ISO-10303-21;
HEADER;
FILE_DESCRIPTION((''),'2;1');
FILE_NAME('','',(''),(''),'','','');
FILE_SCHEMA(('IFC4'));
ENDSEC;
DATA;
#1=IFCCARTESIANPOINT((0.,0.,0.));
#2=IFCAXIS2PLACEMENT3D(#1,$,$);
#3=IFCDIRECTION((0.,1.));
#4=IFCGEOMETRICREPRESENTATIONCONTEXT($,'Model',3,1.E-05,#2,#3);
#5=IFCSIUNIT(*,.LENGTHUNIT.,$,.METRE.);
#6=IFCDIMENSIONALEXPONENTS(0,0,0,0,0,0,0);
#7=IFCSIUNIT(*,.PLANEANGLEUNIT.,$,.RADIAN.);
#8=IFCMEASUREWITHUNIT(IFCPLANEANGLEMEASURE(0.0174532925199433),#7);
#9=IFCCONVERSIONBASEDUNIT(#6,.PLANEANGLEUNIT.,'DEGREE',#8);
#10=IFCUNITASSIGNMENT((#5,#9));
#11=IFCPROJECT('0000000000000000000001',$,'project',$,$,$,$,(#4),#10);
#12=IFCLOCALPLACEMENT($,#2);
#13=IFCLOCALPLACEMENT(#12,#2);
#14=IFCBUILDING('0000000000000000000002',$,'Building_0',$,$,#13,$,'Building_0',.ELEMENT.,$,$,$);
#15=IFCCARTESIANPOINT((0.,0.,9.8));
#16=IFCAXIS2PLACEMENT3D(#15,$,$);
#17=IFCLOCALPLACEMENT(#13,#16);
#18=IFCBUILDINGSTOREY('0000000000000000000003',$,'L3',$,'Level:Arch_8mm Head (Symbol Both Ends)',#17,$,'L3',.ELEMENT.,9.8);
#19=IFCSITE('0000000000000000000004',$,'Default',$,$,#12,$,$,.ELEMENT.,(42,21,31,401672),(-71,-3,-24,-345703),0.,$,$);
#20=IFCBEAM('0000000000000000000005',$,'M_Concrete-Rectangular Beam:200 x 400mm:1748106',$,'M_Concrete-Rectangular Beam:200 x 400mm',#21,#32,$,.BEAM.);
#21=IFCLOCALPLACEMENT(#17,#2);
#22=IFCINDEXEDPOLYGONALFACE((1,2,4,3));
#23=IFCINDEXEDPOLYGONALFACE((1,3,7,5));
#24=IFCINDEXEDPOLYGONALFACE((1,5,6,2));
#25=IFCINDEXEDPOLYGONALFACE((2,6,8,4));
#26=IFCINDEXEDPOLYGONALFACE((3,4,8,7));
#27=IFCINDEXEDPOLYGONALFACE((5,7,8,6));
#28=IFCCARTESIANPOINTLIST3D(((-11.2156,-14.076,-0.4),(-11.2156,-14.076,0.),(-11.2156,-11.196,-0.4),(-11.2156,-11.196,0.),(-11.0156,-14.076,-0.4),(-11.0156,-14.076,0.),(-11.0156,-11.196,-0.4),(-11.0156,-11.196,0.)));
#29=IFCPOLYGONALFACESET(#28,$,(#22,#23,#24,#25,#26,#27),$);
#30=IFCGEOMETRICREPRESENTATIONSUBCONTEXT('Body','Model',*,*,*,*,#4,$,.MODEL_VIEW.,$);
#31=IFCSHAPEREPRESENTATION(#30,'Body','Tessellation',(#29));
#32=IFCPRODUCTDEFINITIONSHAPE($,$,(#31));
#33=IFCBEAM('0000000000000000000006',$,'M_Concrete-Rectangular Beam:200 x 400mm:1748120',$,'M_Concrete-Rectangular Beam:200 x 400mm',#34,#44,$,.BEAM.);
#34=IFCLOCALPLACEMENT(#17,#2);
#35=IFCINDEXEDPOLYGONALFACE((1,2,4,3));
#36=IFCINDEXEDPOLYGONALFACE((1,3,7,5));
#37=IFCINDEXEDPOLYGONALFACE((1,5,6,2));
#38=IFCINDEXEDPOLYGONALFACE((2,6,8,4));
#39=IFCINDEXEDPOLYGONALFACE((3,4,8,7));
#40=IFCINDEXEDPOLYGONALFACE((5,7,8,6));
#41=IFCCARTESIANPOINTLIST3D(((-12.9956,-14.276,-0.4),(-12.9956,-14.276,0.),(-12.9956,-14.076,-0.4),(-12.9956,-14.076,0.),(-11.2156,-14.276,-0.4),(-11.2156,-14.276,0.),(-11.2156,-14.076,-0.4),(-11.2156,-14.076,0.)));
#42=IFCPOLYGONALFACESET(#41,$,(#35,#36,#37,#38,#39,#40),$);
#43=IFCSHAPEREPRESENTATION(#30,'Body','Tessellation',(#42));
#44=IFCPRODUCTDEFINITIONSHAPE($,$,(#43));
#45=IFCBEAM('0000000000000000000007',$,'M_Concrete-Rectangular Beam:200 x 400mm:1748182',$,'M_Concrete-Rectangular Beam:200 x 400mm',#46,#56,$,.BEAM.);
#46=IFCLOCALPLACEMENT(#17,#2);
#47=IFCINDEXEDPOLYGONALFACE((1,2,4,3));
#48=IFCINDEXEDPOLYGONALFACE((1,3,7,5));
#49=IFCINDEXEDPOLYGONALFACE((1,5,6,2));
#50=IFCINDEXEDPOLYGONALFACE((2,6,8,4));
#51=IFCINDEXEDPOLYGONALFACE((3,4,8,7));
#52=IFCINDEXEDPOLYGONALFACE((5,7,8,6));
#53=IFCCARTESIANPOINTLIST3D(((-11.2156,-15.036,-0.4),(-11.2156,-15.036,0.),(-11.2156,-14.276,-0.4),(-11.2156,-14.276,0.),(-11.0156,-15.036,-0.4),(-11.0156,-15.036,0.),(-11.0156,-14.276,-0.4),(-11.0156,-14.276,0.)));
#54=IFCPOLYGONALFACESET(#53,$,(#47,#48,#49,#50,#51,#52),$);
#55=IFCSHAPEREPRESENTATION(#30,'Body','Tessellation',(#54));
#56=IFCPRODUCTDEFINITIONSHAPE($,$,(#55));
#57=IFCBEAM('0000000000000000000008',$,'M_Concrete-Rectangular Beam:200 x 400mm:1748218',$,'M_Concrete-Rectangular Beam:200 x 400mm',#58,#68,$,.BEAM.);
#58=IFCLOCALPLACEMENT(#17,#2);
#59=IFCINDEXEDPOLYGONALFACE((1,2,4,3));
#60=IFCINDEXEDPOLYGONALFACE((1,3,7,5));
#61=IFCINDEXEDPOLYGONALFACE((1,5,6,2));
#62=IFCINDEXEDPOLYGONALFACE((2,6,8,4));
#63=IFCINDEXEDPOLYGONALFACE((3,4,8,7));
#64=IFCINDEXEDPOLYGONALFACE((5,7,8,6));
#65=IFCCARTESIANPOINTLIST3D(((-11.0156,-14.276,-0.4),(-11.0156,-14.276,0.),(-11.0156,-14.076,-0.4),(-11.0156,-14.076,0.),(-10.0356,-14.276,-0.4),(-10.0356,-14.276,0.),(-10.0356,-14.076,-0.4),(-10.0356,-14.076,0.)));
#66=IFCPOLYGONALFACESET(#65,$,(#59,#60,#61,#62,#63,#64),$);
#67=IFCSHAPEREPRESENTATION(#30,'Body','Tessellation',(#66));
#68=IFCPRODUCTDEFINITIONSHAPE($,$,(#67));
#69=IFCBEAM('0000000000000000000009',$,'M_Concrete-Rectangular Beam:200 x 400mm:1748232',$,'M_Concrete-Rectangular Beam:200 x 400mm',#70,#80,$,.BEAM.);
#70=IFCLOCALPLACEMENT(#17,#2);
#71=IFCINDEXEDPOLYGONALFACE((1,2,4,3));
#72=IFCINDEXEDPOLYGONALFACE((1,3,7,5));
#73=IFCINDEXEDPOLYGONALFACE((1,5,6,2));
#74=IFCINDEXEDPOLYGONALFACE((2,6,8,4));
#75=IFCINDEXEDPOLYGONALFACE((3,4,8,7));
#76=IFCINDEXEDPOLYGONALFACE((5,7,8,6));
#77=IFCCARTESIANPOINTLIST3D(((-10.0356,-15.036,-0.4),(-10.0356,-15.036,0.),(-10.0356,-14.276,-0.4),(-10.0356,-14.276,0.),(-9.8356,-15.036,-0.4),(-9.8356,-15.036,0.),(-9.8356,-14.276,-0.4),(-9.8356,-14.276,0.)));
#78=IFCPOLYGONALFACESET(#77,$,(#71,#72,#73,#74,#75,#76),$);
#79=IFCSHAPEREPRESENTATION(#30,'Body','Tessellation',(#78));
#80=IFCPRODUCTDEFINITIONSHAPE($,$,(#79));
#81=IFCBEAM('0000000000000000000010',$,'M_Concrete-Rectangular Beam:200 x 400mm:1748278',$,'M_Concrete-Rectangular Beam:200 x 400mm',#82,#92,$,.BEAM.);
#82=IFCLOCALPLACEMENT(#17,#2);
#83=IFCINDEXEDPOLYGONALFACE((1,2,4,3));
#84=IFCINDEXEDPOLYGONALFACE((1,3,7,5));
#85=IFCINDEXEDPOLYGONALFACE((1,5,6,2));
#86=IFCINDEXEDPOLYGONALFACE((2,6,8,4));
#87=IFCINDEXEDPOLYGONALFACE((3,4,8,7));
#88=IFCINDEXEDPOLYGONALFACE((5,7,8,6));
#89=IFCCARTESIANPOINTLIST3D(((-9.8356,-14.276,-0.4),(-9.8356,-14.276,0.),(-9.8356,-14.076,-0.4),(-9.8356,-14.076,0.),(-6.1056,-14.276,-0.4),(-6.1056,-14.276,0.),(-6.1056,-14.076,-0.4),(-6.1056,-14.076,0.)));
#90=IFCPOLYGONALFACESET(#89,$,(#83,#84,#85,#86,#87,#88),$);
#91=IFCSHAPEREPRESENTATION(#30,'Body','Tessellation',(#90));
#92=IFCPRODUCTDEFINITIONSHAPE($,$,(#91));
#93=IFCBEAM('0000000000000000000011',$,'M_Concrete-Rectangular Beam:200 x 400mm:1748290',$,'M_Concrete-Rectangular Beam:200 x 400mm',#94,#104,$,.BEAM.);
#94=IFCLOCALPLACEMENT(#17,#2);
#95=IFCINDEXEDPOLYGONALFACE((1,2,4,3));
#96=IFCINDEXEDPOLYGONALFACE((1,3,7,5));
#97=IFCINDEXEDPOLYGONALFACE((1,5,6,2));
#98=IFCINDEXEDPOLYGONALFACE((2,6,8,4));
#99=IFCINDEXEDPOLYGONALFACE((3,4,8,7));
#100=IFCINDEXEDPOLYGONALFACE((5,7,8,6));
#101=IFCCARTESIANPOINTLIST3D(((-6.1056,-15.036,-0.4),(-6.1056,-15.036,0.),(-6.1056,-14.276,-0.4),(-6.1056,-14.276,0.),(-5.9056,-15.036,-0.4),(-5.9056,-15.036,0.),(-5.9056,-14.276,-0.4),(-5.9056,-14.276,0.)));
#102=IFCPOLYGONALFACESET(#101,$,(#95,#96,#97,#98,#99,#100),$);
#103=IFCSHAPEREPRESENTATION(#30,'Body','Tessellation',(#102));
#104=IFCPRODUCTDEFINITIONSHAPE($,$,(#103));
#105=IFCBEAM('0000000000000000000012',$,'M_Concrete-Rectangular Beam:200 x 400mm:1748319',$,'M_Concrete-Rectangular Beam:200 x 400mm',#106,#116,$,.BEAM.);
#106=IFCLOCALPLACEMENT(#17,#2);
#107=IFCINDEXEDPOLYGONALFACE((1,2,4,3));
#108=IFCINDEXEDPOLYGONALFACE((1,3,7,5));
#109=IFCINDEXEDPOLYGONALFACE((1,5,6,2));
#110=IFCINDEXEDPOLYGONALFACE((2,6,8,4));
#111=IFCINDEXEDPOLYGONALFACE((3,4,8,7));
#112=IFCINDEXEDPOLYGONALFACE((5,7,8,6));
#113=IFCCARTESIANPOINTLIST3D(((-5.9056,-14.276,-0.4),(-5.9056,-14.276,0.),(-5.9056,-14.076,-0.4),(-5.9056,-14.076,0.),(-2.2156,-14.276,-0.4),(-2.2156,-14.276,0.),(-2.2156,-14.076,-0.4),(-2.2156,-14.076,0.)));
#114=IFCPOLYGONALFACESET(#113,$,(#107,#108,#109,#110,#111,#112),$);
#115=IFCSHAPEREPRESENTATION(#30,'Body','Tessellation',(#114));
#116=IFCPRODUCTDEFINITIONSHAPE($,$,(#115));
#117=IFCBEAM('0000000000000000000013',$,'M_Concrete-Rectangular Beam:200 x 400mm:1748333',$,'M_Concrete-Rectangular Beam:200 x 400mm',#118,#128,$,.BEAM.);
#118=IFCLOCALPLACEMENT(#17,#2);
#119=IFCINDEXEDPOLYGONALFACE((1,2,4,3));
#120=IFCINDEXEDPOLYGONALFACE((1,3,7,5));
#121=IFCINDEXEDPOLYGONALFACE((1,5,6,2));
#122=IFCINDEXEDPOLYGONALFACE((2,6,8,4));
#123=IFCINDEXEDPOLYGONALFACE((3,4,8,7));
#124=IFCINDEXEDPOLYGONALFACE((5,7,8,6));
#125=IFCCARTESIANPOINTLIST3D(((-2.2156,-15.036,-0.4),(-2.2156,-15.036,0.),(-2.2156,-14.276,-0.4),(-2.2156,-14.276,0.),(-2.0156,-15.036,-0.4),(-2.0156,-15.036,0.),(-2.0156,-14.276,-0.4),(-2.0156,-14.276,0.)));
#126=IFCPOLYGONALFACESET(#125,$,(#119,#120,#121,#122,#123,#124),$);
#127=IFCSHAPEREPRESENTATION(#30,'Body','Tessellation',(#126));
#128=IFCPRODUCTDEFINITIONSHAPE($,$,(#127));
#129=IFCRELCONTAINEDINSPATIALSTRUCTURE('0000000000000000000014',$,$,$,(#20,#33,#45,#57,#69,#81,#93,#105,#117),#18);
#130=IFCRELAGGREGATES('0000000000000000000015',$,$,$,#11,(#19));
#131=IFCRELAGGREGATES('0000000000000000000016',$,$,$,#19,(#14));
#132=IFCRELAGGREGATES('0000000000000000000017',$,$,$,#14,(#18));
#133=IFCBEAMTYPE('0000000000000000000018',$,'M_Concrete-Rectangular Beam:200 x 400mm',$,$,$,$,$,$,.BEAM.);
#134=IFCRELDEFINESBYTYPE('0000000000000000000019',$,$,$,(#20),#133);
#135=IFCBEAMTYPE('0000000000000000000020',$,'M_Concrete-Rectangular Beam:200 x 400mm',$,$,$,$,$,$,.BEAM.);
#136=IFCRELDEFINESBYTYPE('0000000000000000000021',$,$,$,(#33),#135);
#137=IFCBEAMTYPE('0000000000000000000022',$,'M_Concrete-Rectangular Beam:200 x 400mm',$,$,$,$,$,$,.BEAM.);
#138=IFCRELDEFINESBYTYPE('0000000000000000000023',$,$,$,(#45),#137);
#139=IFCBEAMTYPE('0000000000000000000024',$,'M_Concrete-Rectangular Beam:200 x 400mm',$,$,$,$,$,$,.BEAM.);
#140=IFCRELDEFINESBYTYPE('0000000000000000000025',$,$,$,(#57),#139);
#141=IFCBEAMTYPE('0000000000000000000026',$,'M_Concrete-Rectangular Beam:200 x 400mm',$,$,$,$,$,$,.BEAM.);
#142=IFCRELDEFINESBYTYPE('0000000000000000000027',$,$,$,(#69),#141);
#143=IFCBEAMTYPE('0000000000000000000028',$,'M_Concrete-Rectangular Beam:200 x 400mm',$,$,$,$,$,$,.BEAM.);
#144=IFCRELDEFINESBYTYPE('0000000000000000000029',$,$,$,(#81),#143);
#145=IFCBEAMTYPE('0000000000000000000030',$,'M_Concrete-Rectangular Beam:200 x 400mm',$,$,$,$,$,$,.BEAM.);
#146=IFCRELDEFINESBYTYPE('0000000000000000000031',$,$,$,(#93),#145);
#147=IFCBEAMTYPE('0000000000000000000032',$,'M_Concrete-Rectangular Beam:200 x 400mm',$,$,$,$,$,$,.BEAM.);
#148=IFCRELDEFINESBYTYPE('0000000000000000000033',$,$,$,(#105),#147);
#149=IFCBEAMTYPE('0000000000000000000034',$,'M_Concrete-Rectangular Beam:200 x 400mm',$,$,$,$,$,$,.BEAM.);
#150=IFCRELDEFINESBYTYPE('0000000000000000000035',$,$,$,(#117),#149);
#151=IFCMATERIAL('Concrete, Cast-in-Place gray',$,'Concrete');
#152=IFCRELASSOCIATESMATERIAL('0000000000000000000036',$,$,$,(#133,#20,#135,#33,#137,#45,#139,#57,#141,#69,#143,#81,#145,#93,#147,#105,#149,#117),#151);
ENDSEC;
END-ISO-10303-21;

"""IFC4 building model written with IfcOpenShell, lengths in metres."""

from ifc_helpers import new_model, entity, si_unit, converted_unit, direction, frame, origin, place, context, subcontext, project, spatial, indexed_curve, outline, extrude, source, transform, mapped, material, type_object, type_shapes, element, save


model = new_model("IFC4")

# Units and contexts
model_context = context("Model", 3, precision=1e-05, world=origin(), true_north=direction((0.0, 1.0)))
body_context = subcontext(model_context, "Body", "Model", "MODEL_VIEW")
ifc_project = project(units=[si_unit("LENGTHUNIT", "METRE"), converted_unit("PLANEANGLEUNIT", "DEGREE", entity("IfcPlaneAngleMeasure", 0.0174532925199433), si_unit("PLANEANGLEUNIT", "RADIAN"), dimensions=[0, 0, 0, 0, 0, 0, 0])], contexts=[model_context])

# Site, building, storey
site_placement = place(None, origin())
site = spatial("IfcSite", under=ifc_project, at=site_placement, Name="Default", CompositionType="ELEMENT", RefLatitude=(42, 21, 31, 401672), RefLongitude=(-71, -3, -24, -345703), RefElevation=0.0)
building_placement = place(site_placement, origin())
building = spatial("IfcBuilding", under=site, at=building_placement, Name="Building_0", LongName="Building_0", CompositionType="ELEMENT")
storey_placement = place(building_placement, frame((0.0, 0.0, 9.8)))
storey = spatial("IfcBuildingStorey", under=building, at=storey_placement, Name="L3", ObjectType="Level:Arch_8mm Head (Symbol Both Ends)", LongName="L3", CompositionType="ELEMENT", Elevation=9.8)

# Beams
ifc_material_1 = material(Name="Concrete, Cast-in-Place gray", Category="Concrete")
beam_type_1 = type_object("IfcBeamType", Name="M_Concrete-Rectangular Beam:200 x 400mm", PredefinedType="BEAM", material=ifc_material_1)
shared_shape_1 = source(origin(), body_context, "Body", "SweptSolid", [
    extrude(outline(indexed_curve([(-0.1, -0.2), (0.1, -0.2), (0.1, 0.2), (-0.1, 0.2), (-0.1, -0.2)], self_intersect=False)), frame((-11.1156, -11.196, 9.6), z_axis=(0.0, -1.0, 0.0), x_axis=(-1.0, 0.0, 0.0)), (0.0, 0.0, 1.0), 2.88),
])
type_shapes(beam_type_1, [shared_shape_1])
beam_1_placement = place(storey_placement, frame((0.0, 0.0, -9.8)))
element("IfcBeam", 1, at=beam_1_placement, inside=storey, type_object=beam_type_1, material=ifc_material_1, Name="M_Concrete-Rectangular Beam:200 x 400mm:1748106", ObjectType="M_Concrete-Rectangular Beam:200 x 400mm", PredefinedType="BEAM", context=body_context, shape_type="MappedRepresentation", body=[
    mapped(shared_shape_1, transform((0.0, 0.0, 0.0), scale=1.0)),
])
beam_type_2 = type_object("IfcBeamType", Name="M_Concrete-Rectangular Beam:200 x 400mm", PredefinedType="BEAM", material=ifc_material_1)
shared_shape_2 = source(origin(), body_context, "Body", "SweptSolid", [
    extrude(outline(indexed_curve([(-0.2, -0.1), (0.2, -0.1), (0.2, 0.1), (-0.2, 0.1), (-0.2, -0.1)], self_intersect=False)), frame((-11.2156, -14.176, 9.6), z_axis=(-1.0, 0.0, 0.0), x_axis=(0.0, 0.0, -1.0)), (0.0, 0.0, 1.0), 1.78),
])
type_shapes(beam_type_2, [shared_shape_2])
beam_2_placement = place(storey_placement, frame((0.0, 0.0, -9.8)))
element("IfcBeam", 2, at=beam_2_placement, inside=storey, type_object=beam_type_2, material=ifc_material_1, Name="M_Concrete-Rectangular Beam:200 x 400mm:1748120", ObjectType="M_Concrete-Rectangular Beam:200 x 400mm", PredefinedType="BEAM", context=body_context, shape_type="MappedRepresentation", body=[
    mapped(shared_shape_2, transform((0.0, 0.0, 0.0), scale=1.0)),
])
beam_type_3 = type_object("IfcBeamType", Name="M_Concrete-Rectangular Beam:200 x 400mm", PredefinedType="BEAM", material=ifc_material_1)
shared_shape_3 = source(origin(), body_context, "Body", "SweptSolid", [
    extrude(outline(indexed_curve([(-0.1, -0.2), (0.1, -0.2), (0.1, 0.2), (-0.1, 0.2), (-0.1, -0.2)], self_intersect=False)), frame((-11.1156, -14.276, 9.6), z_axis=(0.0, -1.0, 0.0), x_axis=(-1.0, 0.0, 0.0)), (0.0, 0.0, 1.0), 0.76),
])
type_shapes(beam_type_3, [shared_shape_3])
beam_3_placement = place(storey_placement, frame((0.0, 0.0, -9.8)))
element("IfcBeam", 3, at=beam_3_placement, inside=storey, type_object=beam_type_3, material=ifc_material_1, Name="M_Concrete-Rectangular Beam:200 x 400mm:1748182", ObjectType="M_Concrete-Rectangular Beam:200 x 400mm", PredefinedType="BEAM", context=body_context, shape_type="MappedRepresentation", body=[
    mapped(shared_shape_3, transform((0.0, 0.0, 0.0), scale=1.0)),
])
beam_type_4 = type_object("IfcBeamType", Name="M_Concrete-Rectangular Beam:200 x 400mm", PredefinedType="BEAM", material=ifc_material_1)
shared_shape_4 = source(origin(), body_context, "Body", "SweptSolid", [
    extrude(outline(indexed_curve([(-0.2, -0.1), (0.2, -0.1), (0.2, 0.1), (-0.2, 0.1), (-0.2, -0.1)], self_intersect=False)), frame((-11.0156, -14.176, 9.6), z_axis=(1.0, 0.0, 0.0), x_axis=(0.0, 0.0, -1.0)), (0.0, 0.0, 1.0), 0.98),
])
type_shapes(beam_type_4, [shared_shape_4])
beam_4_placement = place(storey_placement, frame((0.0, 0.0, -9.8)))
element("IfcBeam", 4, at=beam_4_placement, inside=storey, type_object=beam_type_4, material=ifc_material_1, Name="M_Concrete-Rectangular Beam:200 x 400mm:1748218", ObjectType="M_Concrete-Rectangular Beam:200 x 400mm", PredefinedType="BEAM", context=body_context, shape_type="MappedRepresentation", body=[
    mapped(shared_shape_4, transform((0.0, 0.0, 0.0), scale=1.0)),
])
beam_type_5 = type_object("IfcBeamType", Name="M_Concrete-Rectangular Beam:200 x 400mm", PredefinedType="BEAM", material=ifc_material_1)
shared_shape_5 = source(origin(), body_context, "Body", "SweptSolid", [
    extrude(outline(indexed_curve([(-0.1, -0.2), (0.1, -0.2), (0.1, 0.2), (-0.1, 0.2), (-0.1, -0.2)], self_intersect=False)), frame((-9.9356, -14.276, 9.6), z_axis=(0.0, -1.0, 0.0), x_axis=(-1.0, 0.0, 0.0)), (0.0, 0.0, 1.0), 0.76),
])
type_shapes(beam_type_5, [shared_shape_5])
beam_5_placement = place(storey_placement, frame((0.0, 0.0, -9.8)))
element("IfcBeam", 5, at=beam_5_placement, inside=storey, type_object=beam_type_5, material=ifc_material_1, Name="M_Concrete-Rectangular Beam:200 x 400mm:1748232", ObjectType="M_Concrete-Rectangular Beam:200 x 400mm", PredefinedType="BEAM", context=body_context, shape_type="MappedRepresentation", body=[
    mapped(shared_shape_5, transform((0.0, 0.0, 0.0), scale=1.0)),
])
beam_type_6 = type_object("IfcBeamType", Name="M_Concrete-Rectangular Beam:200 x 400mm", PredefinedType="BEAM", material=ifc_material_1)
shared_shape_6 = source(origin(), body_context, "Body", "SweptSolid", [
    extrude(outline(indexed_curve([(-0.2, -0.1), (0.2, -0.1), (0.2, 0.1), (-0.2, 0.1), (-0.2, -0.1)], self_intersect=False)), frame((-9.8356, -14.176, 9.6), z_axis=(1.0, 0.0, 0.0), x_axis=(0.0, 0.0, -1.0)), (0.0, 0.0, 1.0), 3.73),
])
type_shapes(beam_type_6, [shared_shape_6])
beam_6_placement = place(storey_placement, frame((0.0, 0.0, -9.8)))
element("IfcBeam", 6, at=beam_6_placement, inside=storey, type_object=beam_type_6, material=ifc_material_1, Name="M_Concrete-Rectangular Beam:200 x 400mm:1748278", ObjectType="M_Concrete-Rectangular Beam:200 x 400mm", PredefinedType="BEAM", context=body_context, shape_type="MappedRepresentation", body=[
    mapped(shared_shape_6, transform((0.0, 0.0, 0.0), scale=1.0)),
])
beam_type_7 = type_object("IfcBeamType", Name="M_Concrete-Rectangular Beam:200 x 400mm", PredefinedType="BEAM", material=ifc_material_1)
shared_shape_7 = source(origin(), body_context, "Body", "SweptSolid", [
    extrude(outline(indexed_curve([(-0.1, -0.2), (0.1, -0.2), (0.1, 0.2), (-0.1, 0.2), (-0.1, -0.2)], self_intersect=False)), frame((-6.0056, -14.276, 9.6), z_axis=(0.0, -1.0, 0.0), x_axis=(-1.0, 0.0, 0.0)), (0.0, 0.0, 1.0), 0.76),
])
type_shapes(beam_type_7, [shared_shape_7])
beam_7_placement = place(storey_placement, frame((0.0, 0.0, -9.8)))
element("IfcBeam", 7, at=beam_7_placement, inside=storey, type_object=beam_type_7, material=ifc_material_1, Name="M_Concrete-Rectangular Beam:200 x 400mm:1748290", ObjectType="M_Concrete-Rectangular Beam:200 x 400mm", PredefinedType="BEAM", context=body_context, shape_type="MappedRepresentation", body=[
    mapped(shared_shape_7, transform((0.0, 0.0, 0.0), scale=1.0)),
])
beam_type_8 = type_object("IfcBeamType", Name="M_Concrete-Rectangular Beam:200 x 400mm", PredefinedType="BEAM", material=ifc_material_1)
shared_shape_8 = source(origin(), body_context, "Body", "SweptSolid", [
    extrude(outline(indexed_curve([(-0.2, -0.1), (0.2, -0.1), (0.2, 0.1), (-0.2, 0.1), (-0.2, -0.1)], self_intersect=False)), frame((-5.9056, -14.176, 9.6), z_axis=(1.0, 0.0, 0.0), x_axis=(0.0, 0.0, -1.0)), (0.0, 0.0, 1.0), 3.69),
])
type_shapes(beam_type_8, [shared_shape_8])
beam_8_placement = place(storey_placement, frame((0.0, 0.0, -9.8)))
element("IfcBeam", 8, at=beam_8_placement, inside=storey, type_object=beam_type_8, material=ifc_material_1, Name="M_Concrete-Rectangular Beam:200 x 400mm:1748319", ObjectType="M_Concrete-Rectangular Beam:200 x 400mm", PredefinedType="BEAM", context=body_context, shape_type="MappedRepresentation", body=[
    mapped(shared_shape_8, transform((0.0, 0.0, 0.0), scale=1.0)),
])
beam_type_9 = type_object("IfcBeamType", Name="M_Concrete-Rectangular Beam:200 x 400mm", PredefinedType="BEAM", material=ifc_material_1)
shared_shape_9 = source(origin(), body_context, "Body", "SweptSolid", [
    extrude(outline(indexed_curve([(-0.1, -0.2), (0.1, -0.2), (0.1, 0.2), (-0.1, 0.2), (-0.1, -0.2)], self_intersect=False)), frame((-2.1156, -14.276, 9.6), z_axis=(0.0, -1.0, 0.0), x_axis=(-1.0, 0.0, 0.0)), (0.0, 0.0, 1.0), 0.76),
])
type_shapes(beam_type_9, [shared_shape_9])
beam_9_placement = place(storey_placement, frame((0.0, 0.0, -9.8)))
element("IfcBeam", 9, at=beam_9_placement, inside=storey, type_object=beam_type_9, material=ifc_material_1, Name="M_Concrete-Rectangular Beam:200 x 400mm:1748333", ObjectType="M_Concrete-Rectangular Beam:200 x 400mm", PredefinedType="BEAM", context=body_context, shape_type="MappedRepresentation", body=[
    mapped(shared_shape_9, transform((0.0, 0.0, 0.0), scale=1.0)),
])

save(model, "model.ifc")
